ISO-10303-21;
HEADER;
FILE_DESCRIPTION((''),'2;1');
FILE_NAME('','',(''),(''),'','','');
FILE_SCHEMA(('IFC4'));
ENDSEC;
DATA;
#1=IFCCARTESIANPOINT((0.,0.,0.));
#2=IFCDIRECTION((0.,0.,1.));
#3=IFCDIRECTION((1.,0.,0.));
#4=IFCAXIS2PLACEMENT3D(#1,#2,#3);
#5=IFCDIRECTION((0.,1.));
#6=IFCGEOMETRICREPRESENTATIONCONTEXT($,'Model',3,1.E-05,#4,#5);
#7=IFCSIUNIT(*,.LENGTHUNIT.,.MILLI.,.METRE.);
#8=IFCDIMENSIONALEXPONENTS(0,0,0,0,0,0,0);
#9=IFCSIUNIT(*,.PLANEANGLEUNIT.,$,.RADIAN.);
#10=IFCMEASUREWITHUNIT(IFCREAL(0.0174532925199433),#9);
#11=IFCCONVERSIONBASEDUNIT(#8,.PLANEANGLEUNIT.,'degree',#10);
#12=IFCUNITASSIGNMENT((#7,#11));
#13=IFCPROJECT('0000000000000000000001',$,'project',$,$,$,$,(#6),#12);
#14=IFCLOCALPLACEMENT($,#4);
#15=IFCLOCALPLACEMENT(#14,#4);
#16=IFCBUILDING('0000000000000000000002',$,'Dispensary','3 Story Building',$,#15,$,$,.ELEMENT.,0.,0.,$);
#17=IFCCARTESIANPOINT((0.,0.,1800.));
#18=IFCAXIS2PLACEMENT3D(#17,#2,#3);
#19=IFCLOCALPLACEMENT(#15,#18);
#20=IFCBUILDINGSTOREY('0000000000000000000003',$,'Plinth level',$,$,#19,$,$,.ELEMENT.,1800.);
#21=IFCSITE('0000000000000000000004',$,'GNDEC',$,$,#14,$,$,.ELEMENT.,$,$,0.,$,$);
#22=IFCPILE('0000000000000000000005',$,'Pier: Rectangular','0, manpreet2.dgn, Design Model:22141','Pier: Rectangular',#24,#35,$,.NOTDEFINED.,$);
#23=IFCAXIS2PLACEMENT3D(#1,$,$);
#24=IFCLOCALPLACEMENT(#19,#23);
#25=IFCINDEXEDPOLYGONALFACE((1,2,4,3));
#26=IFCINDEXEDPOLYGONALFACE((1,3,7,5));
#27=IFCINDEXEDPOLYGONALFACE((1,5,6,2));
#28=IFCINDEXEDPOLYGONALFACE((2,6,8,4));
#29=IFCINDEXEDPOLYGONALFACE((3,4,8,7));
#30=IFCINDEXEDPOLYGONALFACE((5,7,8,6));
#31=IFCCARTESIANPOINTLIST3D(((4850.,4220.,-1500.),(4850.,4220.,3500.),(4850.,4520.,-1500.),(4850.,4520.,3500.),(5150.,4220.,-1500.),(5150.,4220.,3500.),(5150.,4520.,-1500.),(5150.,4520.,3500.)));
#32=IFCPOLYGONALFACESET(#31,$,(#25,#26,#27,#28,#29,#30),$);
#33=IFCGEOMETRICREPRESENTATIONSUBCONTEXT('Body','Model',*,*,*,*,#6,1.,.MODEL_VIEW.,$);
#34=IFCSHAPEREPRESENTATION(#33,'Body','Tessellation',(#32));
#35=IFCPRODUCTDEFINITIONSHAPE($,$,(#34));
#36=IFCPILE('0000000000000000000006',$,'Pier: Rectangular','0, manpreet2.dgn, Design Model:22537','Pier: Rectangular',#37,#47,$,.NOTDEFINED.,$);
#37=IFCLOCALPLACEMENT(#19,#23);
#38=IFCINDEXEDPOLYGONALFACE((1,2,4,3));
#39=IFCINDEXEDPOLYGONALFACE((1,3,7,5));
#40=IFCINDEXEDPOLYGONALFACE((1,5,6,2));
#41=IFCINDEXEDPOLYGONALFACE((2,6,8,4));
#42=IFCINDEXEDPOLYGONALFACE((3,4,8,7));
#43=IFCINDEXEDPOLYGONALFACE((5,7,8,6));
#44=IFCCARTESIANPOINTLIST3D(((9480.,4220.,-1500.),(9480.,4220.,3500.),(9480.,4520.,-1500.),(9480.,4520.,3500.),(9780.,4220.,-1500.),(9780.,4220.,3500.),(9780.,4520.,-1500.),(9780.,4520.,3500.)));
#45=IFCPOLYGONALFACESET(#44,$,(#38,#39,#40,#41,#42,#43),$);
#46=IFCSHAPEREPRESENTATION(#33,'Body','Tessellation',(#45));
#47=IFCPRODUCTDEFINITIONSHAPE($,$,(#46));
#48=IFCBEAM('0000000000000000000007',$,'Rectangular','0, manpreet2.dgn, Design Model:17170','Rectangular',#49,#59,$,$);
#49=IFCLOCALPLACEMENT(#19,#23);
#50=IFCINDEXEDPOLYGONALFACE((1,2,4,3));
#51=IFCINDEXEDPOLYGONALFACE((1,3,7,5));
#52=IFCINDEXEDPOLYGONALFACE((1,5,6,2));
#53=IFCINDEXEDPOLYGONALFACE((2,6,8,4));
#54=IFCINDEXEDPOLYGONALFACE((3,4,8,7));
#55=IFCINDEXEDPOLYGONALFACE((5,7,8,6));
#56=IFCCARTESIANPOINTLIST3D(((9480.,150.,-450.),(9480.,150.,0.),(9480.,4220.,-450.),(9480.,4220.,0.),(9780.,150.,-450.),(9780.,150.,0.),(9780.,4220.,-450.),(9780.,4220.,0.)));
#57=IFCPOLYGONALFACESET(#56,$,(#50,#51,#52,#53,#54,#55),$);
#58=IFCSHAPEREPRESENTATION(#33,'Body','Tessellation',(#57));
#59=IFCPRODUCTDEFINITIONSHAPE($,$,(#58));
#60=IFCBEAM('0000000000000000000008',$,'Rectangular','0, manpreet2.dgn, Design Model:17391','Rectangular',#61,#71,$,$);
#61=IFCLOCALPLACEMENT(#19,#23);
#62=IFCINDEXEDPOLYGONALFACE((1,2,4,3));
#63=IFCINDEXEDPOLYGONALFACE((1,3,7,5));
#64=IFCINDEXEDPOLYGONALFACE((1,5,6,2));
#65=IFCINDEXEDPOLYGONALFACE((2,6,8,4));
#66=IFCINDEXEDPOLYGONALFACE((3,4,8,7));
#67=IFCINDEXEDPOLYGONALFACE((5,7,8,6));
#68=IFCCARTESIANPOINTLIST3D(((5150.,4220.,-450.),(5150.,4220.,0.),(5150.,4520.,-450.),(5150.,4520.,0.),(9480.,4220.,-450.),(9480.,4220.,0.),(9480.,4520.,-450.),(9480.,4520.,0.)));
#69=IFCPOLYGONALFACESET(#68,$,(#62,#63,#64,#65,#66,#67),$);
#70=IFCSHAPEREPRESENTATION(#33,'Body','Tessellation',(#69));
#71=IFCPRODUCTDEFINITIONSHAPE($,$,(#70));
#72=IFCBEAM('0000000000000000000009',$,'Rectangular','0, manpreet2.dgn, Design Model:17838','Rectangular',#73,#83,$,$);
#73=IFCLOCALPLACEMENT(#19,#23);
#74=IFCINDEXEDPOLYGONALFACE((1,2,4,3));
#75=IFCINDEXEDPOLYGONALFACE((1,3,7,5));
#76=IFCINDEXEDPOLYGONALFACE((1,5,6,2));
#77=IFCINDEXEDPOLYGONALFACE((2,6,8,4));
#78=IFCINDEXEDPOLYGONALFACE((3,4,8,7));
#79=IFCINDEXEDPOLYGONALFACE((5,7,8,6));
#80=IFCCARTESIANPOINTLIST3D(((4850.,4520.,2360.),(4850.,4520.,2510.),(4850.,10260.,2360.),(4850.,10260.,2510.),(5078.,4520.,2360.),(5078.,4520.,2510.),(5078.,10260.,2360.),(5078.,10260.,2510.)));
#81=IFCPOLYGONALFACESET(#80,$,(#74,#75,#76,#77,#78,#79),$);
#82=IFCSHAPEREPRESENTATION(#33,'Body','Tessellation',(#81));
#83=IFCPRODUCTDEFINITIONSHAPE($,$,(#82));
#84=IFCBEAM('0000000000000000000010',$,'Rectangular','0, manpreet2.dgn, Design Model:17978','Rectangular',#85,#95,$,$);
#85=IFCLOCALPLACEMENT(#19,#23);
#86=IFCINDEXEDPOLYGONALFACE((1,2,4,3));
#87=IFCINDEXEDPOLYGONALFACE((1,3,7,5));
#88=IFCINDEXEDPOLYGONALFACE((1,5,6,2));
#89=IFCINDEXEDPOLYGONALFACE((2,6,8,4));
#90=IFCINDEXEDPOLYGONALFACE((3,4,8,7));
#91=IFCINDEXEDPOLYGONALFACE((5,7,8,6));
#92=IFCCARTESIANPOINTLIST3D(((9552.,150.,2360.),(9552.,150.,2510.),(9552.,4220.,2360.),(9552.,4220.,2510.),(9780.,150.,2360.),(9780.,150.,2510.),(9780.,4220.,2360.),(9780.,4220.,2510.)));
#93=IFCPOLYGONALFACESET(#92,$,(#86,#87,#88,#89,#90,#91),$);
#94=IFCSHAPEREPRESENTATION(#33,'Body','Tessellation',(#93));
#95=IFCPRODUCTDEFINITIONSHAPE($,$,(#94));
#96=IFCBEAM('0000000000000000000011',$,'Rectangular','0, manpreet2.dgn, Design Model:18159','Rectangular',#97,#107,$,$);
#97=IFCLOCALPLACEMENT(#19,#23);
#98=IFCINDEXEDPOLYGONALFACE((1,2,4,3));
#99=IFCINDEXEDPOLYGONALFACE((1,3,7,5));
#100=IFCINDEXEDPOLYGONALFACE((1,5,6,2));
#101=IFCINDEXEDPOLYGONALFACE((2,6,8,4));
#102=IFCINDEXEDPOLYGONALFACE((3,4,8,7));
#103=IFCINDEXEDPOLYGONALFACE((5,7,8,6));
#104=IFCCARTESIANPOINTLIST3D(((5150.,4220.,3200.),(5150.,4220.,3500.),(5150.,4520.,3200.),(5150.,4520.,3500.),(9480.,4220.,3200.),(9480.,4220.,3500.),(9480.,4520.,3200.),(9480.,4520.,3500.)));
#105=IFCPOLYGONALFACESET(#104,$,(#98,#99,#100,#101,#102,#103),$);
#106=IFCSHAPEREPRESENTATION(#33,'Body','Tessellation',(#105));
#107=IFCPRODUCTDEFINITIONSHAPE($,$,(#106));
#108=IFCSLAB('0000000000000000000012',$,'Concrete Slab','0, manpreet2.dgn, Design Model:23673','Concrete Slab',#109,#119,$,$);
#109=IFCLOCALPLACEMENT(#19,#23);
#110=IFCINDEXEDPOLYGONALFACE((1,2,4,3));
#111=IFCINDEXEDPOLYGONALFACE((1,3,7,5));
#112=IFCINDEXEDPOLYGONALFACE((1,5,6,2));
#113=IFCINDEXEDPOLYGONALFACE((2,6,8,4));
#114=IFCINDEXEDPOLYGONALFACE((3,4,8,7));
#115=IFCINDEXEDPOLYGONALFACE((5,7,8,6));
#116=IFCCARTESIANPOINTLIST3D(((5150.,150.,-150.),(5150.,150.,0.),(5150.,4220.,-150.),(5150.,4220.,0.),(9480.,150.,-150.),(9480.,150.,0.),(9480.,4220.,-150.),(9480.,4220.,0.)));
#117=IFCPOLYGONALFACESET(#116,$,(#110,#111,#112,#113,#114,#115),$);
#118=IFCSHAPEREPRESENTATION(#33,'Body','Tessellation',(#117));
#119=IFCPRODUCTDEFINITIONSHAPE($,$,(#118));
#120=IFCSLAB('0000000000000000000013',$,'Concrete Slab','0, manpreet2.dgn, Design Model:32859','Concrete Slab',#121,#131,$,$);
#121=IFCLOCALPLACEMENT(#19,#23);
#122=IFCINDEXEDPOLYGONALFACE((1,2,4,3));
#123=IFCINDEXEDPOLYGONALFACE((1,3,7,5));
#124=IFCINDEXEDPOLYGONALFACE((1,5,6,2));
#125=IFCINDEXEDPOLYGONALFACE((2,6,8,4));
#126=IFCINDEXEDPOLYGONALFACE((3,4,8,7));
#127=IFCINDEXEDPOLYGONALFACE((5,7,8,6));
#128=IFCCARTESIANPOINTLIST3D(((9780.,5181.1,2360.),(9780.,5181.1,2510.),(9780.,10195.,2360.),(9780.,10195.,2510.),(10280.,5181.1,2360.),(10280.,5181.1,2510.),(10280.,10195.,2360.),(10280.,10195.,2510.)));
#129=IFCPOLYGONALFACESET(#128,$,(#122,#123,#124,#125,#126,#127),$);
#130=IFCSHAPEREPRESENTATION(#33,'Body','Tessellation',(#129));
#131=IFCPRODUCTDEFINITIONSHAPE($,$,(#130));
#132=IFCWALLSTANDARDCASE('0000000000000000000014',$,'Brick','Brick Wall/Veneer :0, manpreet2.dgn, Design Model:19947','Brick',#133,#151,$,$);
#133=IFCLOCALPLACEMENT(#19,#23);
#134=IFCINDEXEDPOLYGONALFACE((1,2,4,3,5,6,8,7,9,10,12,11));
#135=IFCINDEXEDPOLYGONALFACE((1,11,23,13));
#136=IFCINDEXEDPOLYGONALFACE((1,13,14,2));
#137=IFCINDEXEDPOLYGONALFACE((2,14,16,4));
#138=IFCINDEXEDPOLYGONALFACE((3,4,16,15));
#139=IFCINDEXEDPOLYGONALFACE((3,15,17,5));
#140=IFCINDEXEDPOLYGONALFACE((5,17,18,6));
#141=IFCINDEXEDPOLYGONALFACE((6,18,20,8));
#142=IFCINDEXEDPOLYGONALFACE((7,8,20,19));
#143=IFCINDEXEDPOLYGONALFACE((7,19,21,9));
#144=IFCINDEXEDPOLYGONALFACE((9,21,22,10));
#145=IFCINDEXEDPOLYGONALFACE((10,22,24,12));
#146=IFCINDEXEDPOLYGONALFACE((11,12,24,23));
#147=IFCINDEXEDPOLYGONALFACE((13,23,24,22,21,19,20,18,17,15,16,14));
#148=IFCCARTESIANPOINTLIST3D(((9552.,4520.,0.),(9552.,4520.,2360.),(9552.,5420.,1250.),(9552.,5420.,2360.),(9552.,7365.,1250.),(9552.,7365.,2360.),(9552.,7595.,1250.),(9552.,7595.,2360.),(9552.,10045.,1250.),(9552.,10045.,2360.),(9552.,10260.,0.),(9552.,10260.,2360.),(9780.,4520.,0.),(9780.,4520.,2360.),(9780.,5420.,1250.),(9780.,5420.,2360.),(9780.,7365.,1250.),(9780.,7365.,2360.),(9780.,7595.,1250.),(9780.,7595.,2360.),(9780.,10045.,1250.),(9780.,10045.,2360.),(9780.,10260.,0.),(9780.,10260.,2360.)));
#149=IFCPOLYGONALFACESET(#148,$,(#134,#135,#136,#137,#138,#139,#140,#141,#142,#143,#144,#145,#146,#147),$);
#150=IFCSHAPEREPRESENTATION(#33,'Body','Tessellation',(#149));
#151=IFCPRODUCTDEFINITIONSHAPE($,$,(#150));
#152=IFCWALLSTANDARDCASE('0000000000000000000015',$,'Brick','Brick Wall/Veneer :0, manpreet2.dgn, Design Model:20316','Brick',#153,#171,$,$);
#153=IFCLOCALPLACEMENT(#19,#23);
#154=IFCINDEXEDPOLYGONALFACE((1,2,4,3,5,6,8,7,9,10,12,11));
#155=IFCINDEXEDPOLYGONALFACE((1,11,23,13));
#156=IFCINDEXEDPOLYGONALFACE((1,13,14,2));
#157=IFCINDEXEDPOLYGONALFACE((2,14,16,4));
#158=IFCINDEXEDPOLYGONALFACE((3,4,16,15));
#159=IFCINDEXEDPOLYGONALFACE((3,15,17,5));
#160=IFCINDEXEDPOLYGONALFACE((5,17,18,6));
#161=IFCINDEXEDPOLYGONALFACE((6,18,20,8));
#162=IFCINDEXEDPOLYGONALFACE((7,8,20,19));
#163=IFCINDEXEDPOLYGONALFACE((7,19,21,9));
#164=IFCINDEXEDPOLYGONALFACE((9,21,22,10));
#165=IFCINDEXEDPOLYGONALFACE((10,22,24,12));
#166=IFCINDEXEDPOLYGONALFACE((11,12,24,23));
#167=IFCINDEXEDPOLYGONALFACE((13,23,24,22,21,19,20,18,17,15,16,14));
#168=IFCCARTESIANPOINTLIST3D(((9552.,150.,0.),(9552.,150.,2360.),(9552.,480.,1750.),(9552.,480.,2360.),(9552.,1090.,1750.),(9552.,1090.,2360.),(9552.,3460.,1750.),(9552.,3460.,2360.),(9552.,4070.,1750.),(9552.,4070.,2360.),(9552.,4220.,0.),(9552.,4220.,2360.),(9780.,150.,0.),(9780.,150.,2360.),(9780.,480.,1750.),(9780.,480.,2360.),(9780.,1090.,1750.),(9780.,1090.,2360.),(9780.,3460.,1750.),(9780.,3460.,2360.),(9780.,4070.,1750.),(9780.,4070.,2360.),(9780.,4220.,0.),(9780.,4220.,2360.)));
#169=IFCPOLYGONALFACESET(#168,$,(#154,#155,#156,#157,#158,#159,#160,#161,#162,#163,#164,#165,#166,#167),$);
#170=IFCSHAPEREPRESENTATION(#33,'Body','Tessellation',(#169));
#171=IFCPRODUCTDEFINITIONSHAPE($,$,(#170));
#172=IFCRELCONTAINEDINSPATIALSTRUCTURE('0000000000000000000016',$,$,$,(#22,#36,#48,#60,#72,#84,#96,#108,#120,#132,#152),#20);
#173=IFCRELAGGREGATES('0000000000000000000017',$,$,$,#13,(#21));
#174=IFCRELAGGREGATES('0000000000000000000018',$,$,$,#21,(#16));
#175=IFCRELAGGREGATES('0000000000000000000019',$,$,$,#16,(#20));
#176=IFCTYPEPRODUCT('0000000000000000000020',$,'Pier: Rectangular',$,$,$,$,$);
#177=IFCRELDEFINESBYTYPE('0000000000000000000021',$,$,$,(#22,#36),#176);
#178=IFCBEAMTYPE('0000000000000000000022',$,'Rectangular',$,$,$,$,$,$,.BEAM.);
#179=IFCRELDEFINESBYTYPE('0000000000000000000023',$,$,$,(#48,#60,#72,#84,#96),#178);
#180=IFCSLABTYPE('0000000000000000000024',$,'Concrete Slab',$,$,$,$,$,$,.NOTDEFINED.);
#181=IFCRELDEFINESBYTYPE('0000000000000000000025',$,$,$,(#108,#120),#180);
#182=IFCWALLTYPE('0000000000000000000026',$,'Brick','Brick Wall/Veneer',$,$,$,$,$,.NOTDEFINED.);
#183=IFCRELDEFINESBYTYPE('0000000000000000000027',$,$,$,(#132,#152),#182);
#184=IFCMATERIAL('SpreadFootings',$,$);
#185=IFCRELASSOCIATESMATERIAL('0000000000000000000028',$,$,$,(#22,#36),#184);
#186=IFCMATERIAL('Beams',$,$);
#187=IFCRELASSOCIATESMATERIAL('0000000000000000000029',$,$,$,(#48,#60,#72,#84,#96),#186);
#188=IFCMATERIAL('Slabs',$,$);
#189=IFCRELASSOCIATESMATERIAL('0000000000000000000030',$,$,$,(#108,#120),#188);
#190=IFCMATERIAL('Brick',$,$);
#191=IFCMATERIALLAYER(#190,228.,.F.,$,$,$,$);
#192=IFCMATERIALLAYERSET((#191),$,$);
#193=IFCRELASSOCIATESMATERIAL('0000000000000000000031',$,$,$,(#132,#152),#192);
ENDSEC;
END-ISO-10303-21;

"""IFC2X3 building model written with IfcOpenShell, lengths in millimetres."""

from ifc_helpers import new_model, entity, si_unit, converted_unit, direction, frame, frame_2d, origin_with_axes, place, context, subcontext, project, spatial, rectangle, extrude, material, layer, layer_set, layer_usage, type_object, element, save


model = new_model("IFC2X3")

# Units and contexts
model_context = context("Model", 3, precision=1e-05, world=origin_with_axes(), true_north=direction((0.0, 1.0)))
body_context = subcontext(model_context, "Body", "Model", "MODEL_VIEW", scale=1.0)
ifc_project = project(units=[si_unit("LENGTHUNIT", "METRE", prefix="MILLI"), converted_unit("PLANEANGLEUNIT", "degree", entity("IfcReal", 0.0174532925199433), si_unit("PLANEANGLEUNIT", "RADIAN"), dimensions=[0, 0, 0, 0, 0, 0, 0])], contexts=[model_context])

# Site, building, storey
site_placement = place(None, origin_with_axes())
site = spatial("IfcSite", under=ifc_project, at=site_placement, Name="GNDEC", CompositionType="ELEMENT", RefElevation=0.0)
building_placement = place(site_placement, origin_with_axes())
building = spatial("IfcBuilding", under=site, at=building_placement, Name="Dispensary", Description="3 Story Building", CompositionType="ELEMENT", ElevationOfRefHeight=0.0, ElevationOfTerrain=0.0)
storey_placement = place(building_placement, frame((0.0, 0.0, 1800.0), z_axis=(0.0, 0.0, 1.0), x_axis=(1.0, 0.0, 0.0)))
storey = spatial("IfcBuildingStorey", under=building, at=storey_placement, Name="Plinth level", CompositionType="ELEMENT", Elevation=1800.0)

# Piles
ifc_material_1 = material(Name="SpreadFootings")
type_product = type_object("IfcTypeProduct", Name="Pier: Rectangular")
for number, where, z_axis, x_axis, name, description in (
    (1, (4850.0, 4520.0, -1500.0), (0.0, 0.0, 1.0), (0.0, -1.0, 0.0), "Pier: Rectangular", "0, manpreet2.dgn, Design Model:22141"),
    (2, (9480.0, 4520.0, -1500.0), (0.0, 0.0, 1.0), (0.0, -1.0, 0.0), "Pier: Rectangular", "0, manpreet2.dgn, Design Model:22537"),
):
    element("IfcPile", number, at=place(storey_placement, frame(where, z_axis=z_axis, x_axis=x_axis)), inside=storey, type_object=type_product, material=ifc_material_1, Name=name, Description=description, ObjectType="Pier: Rectangular", PredefinedType="NOTDEFINED", context=body_context, shape_type="SweptSolid", body=[
        extrude(rectangle(XDim=300.0, YDim=300.0, at=frame_2d((150.0, 150.0), x_axis=(0.0, 1.0))), origin_with_axes(), (0.0, 0.0, 1.0), 5000.0),
    ])

# Beams
ifc_material_2 = material(Name="Beams")
beam_type = type_object("IfcBeamType", Name="Rectangular", PredefinedType="BEAM")
beam_1_placement = place(storey_placement, frame((9780.0, 4220.0, -450.0), z_axis=(0.0, -1.0, 0.0), x_axis=(0.0, 0.0, 1.0)))
element("IfcBeam", 3, at=beam_1_placement, inside=storey, type_object=beam_type, material=ifc_material_2, Name="Rectangular", Description="0, manpreet2.dgn, Design Model:17170", ObjectType="Rectangular", context=body_context, shape_type="SweptSolid", body=[
    extrude(rectangle(XDim=300.0, YDim=450.0, at=frame_2d((225.0, 150.0), x_axis=(0.0, 1.0))), origin_with_axes(), (0.0, 0.0, 1.0), 4070.0),
])
beam_2_placement = place(storey_placement, frame((5150.0, 4520.0, -450.0), z_axis=(1.0, 0.0, 0.0), x_axis=(0.0, 0.0, 1.0)))
element("IfcBeam", 4, at=beam_2_placement, inside=storey, type_object=beam_type, material=ifc_material_2, Name="Rectangular", Description="0, manpreet2.dgn, Design Model:17391", ObjectType="Rectangular", context=body_context, shape_type="SweptSolid", body=[
    extrude(rectangle(XDim=300.0, YDim=450.0, at=frame_2d((225.0, 150.0), x_axis=(0.0, 1.0))), origin_with_axes(), (0.0, 0.0, 1.0), 4330.0),
])
beam_3_placement = place(storey_placement, frame((5078.0, 4520.0, 2360.0), z_axis=(0.0, 1.0, 0.0), x_axis=(-1.0, 0.0, 0.0)))
element("IfcBeam", 5, at=beam_3_placement, inside=storey, type_object=beam_type, material=ifc_material_2, Name="Rectangular", Description="0, manpreet2.dgn, Design Model:17838", ObjectType="Rectangular", context=body_context, shape_type="SweptSolid", body=[
    extrude(rectangle(XDim=150.0, YDim=228.0, at=frame_2d((114.0, 75.0), x_axis=(0.0, 1.0))), origin_with_axes(), (0.0, 0.0, 1.0), 5740.0),
])
beam_4_placement = place(storey_placement, frame((9552.0, 4220.0, 2360.0), z_axis=(0.0, -1.0, 0.0), x_axis=(1.0, 0.0, 0.0)))
element("IfcBeam", 6, at=beam_4_placement, inside=storey, type_object=beam_type, material=ifc_material_2, Name="Rectangular", Description="0, manpreet2.dgn, Design Model:17978", ObjectType="Rectangular", context=body_context, shape_type="SweptSolid", body=[
    extrude(rectangle(XDim=150.0, YDim=228.0, at=frame_2d((114.0, 75.0), x_axis=(0.0, 1.0))), origin_with_axes(), (0.0, 0.0, 1.0), 4070.0),
])
beam_5_placement = place(storey_placement, frame((5150.0, 4220.0, 3200.0), z_axis=(1.0, 0.0, 0.0), x_axis=(0.0, 1.0, 0.0)))
element("IfcBeam", 7, at=beam_5_placement, inside=storey, type_object=beam_type, material=ifc_material_2, Name="Rectangular", Description="0, manpreet2.dgn, Design Model:18159", ObjectType="Rectangular", context=body_context, shape_type="SweptSolid", body=[
    extrude(rectangle(XDim=300.0, YDim=300.0, at=frame_2d((150.0, 150.0), x_axis=(0.0, 1.0))), origin_with_axes(), (0.0, 0.0, 1.0), 4330.0),
])

# Slabs
ifc_material_3 = material(Name="Slabs")
slab_type = type_object("IfcSlabType", Name="Concrete Slab", PredefinedType="NOTDEFINED")
slab_1_placement = place(storey_placement, frame((5150.0, 4220.0, 0.0), z_axis=(0.0, 0.0, -1.0), x_axis=(1.0, 0.0, 0.0)))
element("IfcSlab", 8, at=slab_1_placement, inside=storey, type_object=slab_type, material=ifc_material_3, Name="Concrete Slab", Description="0, manpreet2.dgn, Design Model:23673", ObjectType="Concrete Slab", context=body_context, shape_type="SweptSolid", body=[
    extrude(rectangle(XDim=4330.0, YDim=4070.0, at=frame_2d((2165.0, 2035.0), x_axis=(1.0, 0.0))), origin_with_axes(), (0.0, 0.0, 1.0), 150.0),
])
slab_2_placement = place(storey_placement, frame((9780.0, 10045.0, 2510.0), z_axis=(0.0, 0.0, -1.0), x_axis=(0.0, 1.0, 0.0)))
element("IfcSlab", 9, at=slab_2_placement, inside=storey, type_object=slab_type, material=ifc_material_3, Name="Concrete Slab", Description="0, manpreet2.dgn, Design Model:32859", ObjectType="Concrete Slab", context=body_context, shape_type="SweptSolid", body=[
    extrude(rectangle(XDim=500.0, YDim=5013.9, at=frame_2d((-2357.0, 250.0), x_axis=(0.0, 1.0))), origin_with_axes(), (0.0, 0.0, 1.0), 150.0),
])

# Walls, openings
ifc_material_4 = material(Name="Brick")
ifc_layer_1 = layer(ifc_material_4, 228.0, ventilated=False)
ifc_layer_set_1 = layer_set([ifc_layer_1])
ifc_layer_usage_1 = layer_usage(ifc_layer_set_1, "AXIS2", "POSITIVE", 0.0)
wall_type = type_object("IfcWallType", Name="Brick", Description="Brick Wall/Veneer", PredefinedType="NOTDEFINED")
wall_1_placement = place(storey_placement, frame((9780.0, 4520.0, 0.0), z_axis=(0.0, 0.0, 1.0), x_axis=(0.0, 1.0, 0.0)))
wall_1 = element("IfcWallStandardCase", 10, at=wall_1_placement, inside=storey, type_object=wall_type, material=ifc_layer_usage_1, Name="Brick", Description="Brick Wall/Veneer :0, manpreet2.dgn, Design Model:19947", ObjectType="Brick", context=body_context, shape_type="SweptSolid", body=[
    extrude(rectangle(XDim=5740.0, YDim=228.0, at=frame_2d((2870.0, 114.0), x_axis=(-1.0, 0.0))), origin_with_axes(), (0.0, 0.0, 1.0), 2360.0),
])
opening_1_placement = place(wall_1_placement, frame((900.0, 0.0, 1250.0), z_axis=(0.0, 0.0, 1.0), x_axis=(1.0, 0.0, 0.0)))
element("IfcOpeningElement", 11, at=opening_1_placement, cuts=wall_1, ObjectType="Opening", context=body_context, shape_type="SweptSolid", body=[
    extrude(rectangle(XDim=1110.0, YDim=1945.0, at=frame_2d((-972.5, 555.0), x_axis=(0.0, -1.0))), frame((0.0, 0.0, 0.0), z_axis=(0.0, 1.0, 0.0), x_axis=(-1.0, 0.0, 0.0)), (0.0, 0.0, 1.0), 228.0),
])
opening_2_placement = place(wall_1_placement, frame((3075.0, 0.0, 1250.0), z_axis=(0.0, 0.0, 1.0), x_axis=(1.0, 0.0, 0.0)))
element("IfcOpeningElement", 12, at=opening_2_placement, cuts=wall_1, ObjectType="Opening", context=body_context, shape_type="SweptSolid", body=[
    extrude(rectangle(XDim=1110.0, YDim=2450.0, at=frame_2d((-1225.0, 555.0), x_axis=(0.0, -1.0))), frame((0.0, 0.0, 0.0), z_axis=(0.0, 1.0, 0.0), x_axis=(-1.0, 0.0, 0.0)), (0.0, 0.0, 1.0), 228.0),
])
wall_2_placement = place(storey_placement, frame((9780.0, 4220.0, 0.0), z_axis=(0.0, 0.0, 1.0), x_axis=(0.0, -1.0, 0.0)))
wall_2 = element("IfcWallStandardCase", 13, at=wall_2_placement, inside=storey, type_object=wall_type, material=ifc_layer_usage_1, Name="Brick", Description="Brick Wall/Veneer :0, manpreet2.dgn, Design Model:20316", ObjectType="Brick", context=body_context, shape_type="SweptSolid", body=[
    extrude(rectangle(XDim=4070.0, YDim=228.0, at=frame_2d((2035.0, -114.0), x_axis=(-1.0, 0.0))), origin_with_axes(), (0.0, 0.0, 1.0), 2360.0),
])
opening_3_placement = place(wall_2_placement, frame((150.0, -228.0, 1750.0), z_axis=(0.0, 0.0, 1.0), x_axis=(1.0, 0.0, 0.0)))
element("IfcOpeningElement", 14, at=opening_3_placement, cuts=wall_2, ObjectType="Opening", context=body_context, shape_type="SweptSolid", body=[
    extrude(rectangle(XDim=1370.0, YDim=610.0, at=frame_2d((-305.0, 685.0), x_axis=(0.0, -1.0))), frame((0.0, 0.0, 0.0), z_axis=(0.0, 1.0, 0.0), x_axis=(-1.0, 0.0, 0.0)), (0.0, 0.0, 1.0), 228.0),
])
opening_4_placement = place(wall_2_placement, frame((3130.0, -228.0, 1750.0), z_axis=(0.0, 0.0, 1.0), x_axis=(1.0, 0.0, 0.0)))
element("IfcOpeningElement", 15, at=opening_4_placement, cuts=wall_2, ObjectType="Opening", context=body_context, shape_type="SweptSolid", body=[
    extrude(rectangle(XDim=1370.0, YDim=610.0, at=frame_2d((-305.0, 685.0), x_axis=(0.0, -1.0))), frame((0.0, 0.0, 0.0), z_axis=(0.0, 1.0, 0.0), x_axis=(-1.0, 0.0, 0.0)), (0.0, 0.0, 1.0), 228.0),
])

save(model, "model.ifc")
